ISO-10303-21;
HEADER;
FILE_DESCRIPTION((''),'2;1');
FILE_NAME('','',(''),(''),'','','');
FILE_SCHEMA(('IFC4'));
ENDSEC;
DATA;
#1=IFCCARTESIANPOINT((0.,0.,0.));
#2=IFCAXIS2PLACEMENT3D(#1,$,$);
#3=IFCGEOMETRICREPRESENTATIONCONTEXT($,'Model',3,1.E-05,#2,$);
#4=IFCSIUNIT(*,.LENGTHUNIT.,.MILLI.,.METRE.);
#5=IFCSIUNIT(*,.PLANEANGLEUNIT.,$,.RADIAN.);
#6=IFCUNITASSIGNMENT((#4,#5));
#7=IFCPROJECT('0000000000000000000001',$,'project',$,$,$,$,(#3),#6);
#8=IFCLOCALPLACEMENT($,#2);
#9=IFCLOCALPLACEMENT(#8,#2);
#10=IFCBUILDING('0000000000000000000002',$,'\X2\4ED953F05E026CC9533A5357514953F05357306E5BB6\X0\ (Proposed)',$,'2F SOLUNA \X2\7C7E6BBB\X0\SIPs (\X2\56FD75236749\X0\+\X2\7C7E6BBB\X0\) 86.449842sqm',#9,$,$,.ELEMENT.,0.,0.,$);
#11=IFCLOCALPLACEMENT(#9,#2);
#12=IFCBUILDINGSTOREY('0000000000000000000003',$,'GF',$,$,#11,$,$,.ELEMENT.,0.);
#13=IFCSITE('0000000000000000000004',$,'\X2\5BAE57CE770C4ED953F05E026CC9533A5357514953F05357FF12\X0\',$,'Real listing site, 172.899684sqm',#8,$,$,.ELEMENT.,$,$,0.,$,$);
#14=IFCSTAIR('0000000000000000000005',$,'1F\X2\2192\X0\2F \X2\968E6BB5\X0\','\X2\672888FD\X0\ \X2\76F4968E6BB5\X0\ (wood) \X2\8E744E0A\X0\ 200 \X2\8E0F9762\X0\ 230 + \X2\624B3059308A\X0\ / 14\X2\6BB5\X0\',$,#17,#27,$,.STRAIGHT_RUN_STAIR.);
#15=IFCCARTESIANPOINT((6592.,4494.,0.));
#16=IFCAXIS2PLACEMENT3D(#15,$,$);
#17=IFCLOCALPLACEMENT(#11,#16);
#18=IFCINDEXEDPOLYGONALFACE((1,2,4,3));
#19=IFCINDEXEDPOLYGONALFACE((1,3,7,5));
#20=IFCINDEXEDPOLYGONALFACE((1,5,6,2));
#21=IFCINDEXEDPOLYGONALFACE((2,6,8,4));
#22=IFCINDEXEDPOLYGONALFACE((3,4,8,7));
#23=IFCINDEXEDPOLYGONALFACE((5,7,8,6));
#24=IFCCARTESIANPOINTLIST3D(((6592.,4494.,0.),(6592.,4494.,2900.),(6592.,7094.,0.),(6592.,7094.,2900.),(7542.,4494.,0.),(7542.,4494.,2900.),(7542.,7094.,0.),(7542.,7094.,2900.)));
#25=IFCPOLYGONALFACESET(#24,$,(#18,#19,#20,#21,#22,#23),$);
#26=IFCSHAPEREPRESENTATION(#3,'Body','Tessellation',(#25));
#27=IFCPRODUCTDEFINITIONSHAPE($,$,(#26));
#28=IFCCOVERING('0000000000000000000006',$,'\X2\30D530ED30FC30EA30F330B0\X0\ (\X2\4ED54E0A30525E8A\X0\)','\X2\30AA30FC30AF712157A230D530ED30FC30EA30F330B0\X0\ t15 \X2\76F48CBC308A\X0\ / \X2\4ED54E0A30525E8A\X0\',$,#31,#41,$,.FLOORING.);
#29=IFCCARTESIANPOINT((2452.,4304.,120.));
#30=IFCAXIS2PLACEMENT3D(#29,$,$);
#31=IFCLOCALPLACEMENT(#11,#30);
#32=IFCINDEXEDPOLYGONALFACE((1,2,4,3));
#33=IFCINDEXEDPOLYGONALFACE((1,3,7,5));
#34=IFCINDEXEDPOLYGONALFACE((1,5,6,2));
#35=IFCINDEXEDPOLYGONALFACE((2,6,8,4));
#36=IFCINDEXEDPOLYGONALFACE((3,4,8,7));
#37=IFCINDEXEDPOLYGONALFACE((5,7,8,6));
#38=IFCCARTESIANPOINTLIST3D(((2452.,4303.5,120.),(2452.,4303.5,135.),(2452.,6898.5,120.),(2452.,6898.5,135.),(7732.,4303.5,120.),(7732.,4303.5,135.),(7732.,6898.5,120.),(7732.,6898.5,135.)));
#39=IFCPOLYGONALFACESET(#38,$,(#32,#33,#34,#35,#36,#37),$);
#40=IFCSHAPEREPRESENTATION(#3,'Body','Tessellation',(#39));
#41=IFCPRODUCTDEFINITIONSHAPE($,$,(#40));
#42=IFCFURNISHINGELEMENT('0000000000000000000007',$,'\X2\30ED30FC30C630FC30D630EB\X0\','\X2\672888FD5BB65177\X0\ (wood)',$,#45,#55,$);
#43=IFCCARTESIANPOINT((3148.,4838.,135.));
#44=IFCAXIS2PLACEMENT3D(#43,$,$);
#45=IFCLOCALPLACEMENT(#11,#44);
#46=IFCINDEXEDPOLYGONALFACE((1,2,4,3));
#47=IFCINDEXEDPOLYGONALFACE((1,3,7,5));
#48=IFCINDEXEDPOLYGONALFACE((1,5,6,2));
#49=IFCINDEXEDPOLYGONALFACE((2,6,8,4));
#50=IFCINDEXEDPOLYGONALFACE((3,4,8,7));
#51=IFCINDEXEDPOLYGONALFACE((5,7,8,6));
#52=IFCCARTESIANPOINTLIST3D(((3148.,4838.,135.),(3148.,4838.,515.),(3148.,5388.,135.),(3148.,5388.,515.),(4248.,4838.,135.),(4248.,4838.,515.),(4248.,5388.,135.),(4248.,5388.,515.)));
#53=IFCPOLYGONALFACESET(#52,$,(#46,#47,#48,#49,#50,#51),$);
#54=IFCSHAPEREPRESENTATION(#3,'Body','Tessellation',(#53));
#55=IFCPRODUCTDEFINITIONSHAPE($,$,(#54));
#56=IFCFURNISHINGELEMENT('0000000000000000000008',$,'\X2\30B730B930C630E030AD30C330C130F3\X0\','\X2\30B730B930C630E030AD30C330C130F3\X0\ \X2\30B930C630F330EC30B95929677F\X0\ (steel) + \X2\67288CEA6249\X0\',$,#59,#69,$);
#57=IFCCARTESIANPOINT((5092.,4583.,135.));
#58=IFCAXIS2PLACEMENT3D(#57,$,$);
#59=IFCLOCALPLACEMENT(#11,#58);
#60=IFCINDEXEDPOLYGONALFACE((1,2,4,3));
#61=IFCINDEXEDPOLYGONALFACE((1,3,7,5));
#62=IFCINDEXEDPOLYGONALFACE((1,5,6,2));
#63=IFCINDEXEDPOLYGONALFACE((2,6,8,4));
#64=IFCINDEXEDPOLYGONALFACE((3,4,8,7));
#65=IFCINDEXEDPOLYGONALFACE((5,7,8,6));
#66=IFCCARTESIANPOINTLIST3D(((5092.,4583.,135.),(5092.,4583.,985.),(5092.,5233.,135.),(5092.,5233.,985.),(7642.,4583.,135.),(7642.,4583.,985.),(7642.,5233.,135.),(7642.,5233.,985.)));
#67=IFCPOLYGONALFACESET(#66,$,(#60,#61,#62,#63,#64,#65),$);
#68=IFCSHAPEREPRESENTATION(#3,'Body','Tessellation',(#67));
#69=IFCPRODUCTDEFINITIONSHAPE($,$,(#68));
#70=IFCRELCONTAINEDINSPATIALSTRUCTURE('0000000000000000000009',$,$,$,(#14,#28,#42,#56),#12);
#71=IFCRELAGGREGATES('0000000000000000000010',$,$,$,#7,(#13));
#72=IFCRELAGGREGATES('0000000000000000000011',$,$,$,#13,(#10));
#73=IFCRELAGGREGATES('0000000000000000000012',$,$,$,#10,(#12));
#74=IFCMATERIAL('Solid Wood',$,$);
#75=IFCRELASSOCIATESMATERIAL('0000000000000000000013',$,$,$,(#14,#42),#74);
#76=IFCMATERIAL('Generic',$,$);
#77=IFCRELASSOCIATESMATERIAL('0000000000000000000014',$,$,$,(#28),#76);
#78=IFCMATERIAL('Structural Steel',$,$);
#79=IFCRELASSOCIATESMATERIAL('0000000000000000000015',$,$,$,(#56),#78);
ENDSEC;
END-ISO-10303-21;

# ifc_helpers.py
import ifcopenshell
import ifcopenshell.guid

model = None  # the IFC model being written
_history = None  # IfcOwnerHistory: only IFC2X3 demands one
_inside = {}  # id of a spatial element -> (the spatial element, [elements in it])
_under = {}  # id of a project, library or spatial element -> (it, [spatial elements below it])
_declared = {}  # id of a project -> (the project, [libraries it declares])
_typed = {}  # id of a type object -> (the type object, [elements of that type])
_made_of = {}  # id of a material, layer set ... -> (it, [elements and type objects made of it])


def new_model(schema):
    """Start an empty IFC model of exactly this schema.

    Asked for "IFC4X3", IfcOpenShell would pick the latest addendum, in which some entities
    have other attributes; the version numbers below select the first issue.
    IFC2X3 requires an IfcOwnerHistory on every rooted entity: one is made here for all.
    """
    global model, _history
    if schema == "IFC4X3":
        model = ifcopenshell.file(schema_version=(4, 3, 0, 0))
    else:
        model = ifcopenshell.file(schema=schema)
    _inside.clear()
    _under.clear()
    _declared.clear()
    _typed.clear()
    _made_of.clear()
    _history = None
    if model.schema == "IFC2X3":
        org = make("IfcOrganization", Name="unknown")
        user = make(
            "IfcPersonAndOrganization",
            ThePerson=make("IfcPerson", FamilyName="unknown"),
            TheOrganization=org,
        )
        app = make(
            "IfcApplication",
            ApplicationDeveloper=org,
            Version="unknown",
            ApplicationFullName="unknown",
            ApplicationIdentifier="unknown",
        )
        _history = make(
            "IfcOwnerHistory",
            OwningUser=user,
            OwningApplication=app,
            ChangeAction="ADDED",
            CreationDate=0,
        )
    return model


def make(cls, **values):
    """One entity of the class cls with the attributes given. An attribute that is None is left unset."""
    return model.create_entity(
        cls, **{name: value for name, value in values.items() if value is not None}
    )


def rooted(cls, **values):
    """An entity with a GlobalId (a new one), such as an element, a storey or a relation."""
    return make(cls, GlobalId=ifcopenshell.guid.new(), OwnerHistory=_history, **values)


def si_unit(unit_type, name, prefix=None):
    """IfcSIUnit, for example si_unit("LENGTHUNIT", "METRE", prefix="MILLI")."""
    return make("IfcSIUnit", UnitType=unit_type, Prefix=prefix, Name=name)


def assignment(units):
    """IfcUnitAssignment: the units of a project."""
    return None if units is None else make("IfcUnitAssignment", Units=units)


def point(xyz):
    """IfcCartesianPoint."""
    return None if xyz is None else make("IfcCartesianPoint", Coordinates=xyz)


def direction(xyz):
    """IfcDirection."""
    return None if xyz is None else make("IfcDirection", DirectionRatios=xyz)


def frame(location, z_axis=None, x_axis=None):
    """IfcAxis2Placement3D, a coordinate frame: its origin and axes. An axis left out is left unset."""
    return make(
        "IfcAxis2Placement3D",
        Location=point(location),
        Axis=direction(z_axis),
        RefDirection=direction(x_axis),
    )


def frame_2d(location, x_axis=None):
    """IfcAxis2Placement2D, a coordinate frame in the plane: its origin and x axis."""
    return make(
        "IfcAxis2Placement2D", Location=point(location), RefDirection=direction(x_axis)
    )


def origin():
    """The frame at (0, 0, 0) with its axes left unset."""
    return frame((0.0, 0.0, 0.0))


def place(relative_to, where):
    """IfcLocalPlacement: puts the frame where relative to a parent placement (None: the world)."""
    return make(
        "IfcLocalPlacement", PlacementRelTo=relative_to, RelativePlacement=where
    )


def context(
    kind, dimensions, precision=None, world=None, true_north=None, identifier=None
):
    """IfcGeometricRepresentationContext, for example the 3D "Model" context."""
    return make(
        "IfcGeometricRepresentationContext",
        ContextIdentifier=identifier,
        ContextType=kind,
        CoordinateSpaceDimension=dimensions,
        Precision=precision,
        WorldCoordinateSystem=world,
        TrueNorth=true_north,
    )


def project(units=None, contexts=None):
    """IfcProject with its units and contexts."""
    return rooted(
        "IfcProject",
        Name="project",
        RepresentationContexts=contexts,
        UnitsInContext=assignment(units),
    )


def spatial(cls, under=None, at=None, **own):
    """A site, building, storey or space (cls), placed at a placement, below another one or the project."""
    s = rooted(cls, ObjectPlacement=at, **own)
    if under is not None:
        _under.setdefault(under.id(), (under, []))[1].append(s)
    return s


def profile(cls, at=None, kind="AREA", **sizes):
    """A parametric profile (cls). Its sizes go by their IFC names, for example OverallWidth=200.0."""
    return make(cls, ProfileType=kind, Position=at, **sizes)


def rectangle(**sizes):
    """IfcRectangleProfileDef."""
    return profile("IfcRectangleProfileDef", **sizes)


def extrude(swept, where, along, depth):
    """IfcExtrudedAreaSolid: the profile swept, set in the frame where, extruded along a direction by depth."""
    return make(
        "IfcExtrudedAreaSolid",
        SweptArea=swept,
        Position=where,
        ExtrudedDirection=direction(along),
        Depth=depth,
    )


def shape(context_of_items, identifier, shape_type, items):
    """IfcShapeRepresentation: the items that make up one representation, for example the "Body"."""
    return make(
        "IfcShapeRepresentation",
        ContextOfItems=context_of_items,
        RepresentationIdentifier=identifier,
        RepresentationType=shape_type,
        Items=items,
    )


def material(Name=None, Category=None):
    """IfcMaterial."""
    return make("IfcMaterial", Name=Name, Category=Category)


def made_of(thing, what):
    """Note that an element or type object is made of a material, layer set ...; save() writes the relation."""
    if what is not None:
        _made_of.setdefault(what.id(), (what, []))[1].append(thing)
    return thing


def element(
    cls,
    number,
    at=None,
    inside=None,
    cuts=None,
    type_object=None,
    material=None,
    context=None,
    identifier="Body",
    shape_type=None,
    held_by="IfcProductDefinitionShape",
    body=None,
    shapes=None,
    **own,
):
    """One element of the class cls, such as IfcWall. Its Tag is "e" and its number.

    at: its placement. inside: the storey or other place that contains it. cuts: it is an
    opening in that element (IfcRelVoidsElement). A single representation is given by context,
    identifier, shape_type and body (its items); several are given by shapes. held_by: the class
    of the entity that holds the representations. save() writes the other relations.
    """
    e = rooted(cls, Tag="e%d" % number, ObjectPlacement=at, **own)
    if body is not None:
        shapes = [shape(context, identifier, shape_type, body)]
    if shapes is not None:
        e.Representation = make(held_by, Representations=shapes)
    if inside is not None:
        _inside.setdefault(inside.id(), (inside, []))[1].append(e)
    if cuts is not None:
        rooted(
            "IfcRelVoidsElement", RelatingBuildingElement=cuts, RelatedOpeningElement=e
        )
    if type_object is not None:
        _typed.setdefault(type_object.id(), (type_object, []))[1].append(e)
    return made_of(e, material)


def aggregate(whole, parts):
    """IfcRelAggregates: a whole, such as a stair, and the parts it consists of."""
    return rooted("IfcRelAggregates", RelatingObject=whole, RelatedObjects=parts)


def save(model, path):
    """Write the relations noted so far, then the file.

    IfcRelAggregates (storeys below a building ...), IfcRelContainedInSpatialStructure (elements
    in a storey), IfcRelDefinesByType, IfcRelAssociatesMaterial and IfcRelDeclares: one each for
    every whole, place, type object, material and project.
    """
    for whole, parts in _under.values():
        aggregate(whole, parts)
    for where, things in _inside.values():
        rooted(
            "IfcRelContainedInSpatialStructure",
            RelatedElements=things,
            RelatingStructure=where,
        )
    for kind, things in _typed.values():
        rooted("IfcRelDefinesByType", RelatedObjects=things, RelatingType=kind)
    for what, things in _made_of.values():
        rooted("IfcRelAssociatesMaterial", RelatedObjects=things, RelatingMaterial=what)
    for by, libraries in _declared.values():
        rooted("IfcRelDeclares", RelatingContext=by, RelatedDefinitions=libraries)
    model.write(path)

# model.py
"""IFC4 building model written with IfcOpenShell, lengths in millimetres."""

from ifc_helpers import new_model, si_unit, frame, frame_2d, origin, place, context, project, spatial, rectangle, extrude, material, element, save


model = new_model("IFC4")

# Units and contexts
model_context = context("Model", 3, precision=1e-05, world=origin())
ifc_project = project(units=[si_unit("LENGTHUNIT", "METRE", prefix="MILLI"), si_unit("PLANEANGLEUNIT", "RADIAN")], contexts=[model_context])

# Site, building, storey
site_placement = place(None, origin())
site = spatial("IfcSite", under=ifc_project, at=site_placement, Name="宮城県仙台市泉区南光台南２", ObjectType="Real listing site, 172.899684sqm", CompositionType="ELEMENT", RefElevation=0.0)
building_placement = place(site_placement, origin())
building = spatial("IfcBuilding", under=site, at=building_placement, Name="仙台市泉区南光台南の家 (Proposed)", ObjectType="2F SOLUNA 籾殻SIPs (国産杉+籾殻) 86.449842sqm", CompositionType="ELEMENT", ElevationOfRefHeight=0.0, ElevationOfTerrain=0.0)
storey_placement = place(building_placement, origin())
storey = spatial("IfcBuildingStorey", under=building, at=storey_placement, Name="GF", CompositionType="ELEMENT", Elevation=0.0)

# Shared definitions
ifc_material_1 = material(Name="Solid Wood")

# Stair
stair_placement = place(storey_placement, frame((6592.0, 4494.0, 0.0)))
element("IfcStair", 1, at=stair_placement, inside=storey, material=ifc_material_1, Name="1F→2F 階段", Description="木製 直階段 (wood) 蹴上 200 踏面 230 + 手すり / 14段", PredefinedType="STRAIGHT_RUN_STAIR", context=model_context, shape_type="SweptSolid", body=[
    extrude(rectangle(XDim=950.0, YDim=2600.0, at=frame_2d((475.0, 1300.0))), frame((6592.0, 4494.0, 0.0)), (0.0, 0.0, 1.0), 2900.0),
])

# Covering
ifc_material_2 = material(Name="Generic")
covering_placement = place(storey_placement, frame((2452.0, 4304.0, 120.0)))
element("IfcCovering", 2, at=covering_placement, inside=storey, material=ifc_material_2, Name="フローリング (仕上げ床)", Description="オーク無垢フローリング t15 直貼り / 仕上げ床", PredefinedType="FLOORING", context=model_context, shape_type="SweptSolid", body=[
    extrude(rectangle(XDim=5280.0, YDim=2595.0, at=frame_2d((2640.0, 1297.0))), frame((2452.0, 4304.0, 120.0)), (0.0, 0.0, 1.0), 15.0),
])

# Furnishing elements
furnishing_1_placement = place(storey_placement, frame((3148.0, 4838.0, 135.0)))
element("IfcFurnishingElement", 3, at=furnishing_1_placement, inside=storey, material=ifc_material_1, Name="ローテーブル", Description="木製家具 (wood)", context=model_context, shape_type="SweptSolid", body=[
    extrude(rectangle(XDim=1100.0, YDim=550.0, at=frame_2d((550.0, 275.0))), frame((3148.0, 4838.0, 135.0)), (0.0, 0.0, 1.0), 380.0),
])
ifc_material_3 = material(Name="Structural Steel")
furnishing_2_placement = place(storey_placement, frame((5092.0, 4583.0, 135.0)))
element("IfcFurnishingElement", 4, at=furnishing_2_placement, inside=storey, material=ifc_material_3, Name="システムキッチン", Description="システムキッチン ステンレス天板 (steel) + 木質扉", context=model_context, shape_type="SweptSolid", body=[
    extrude(rectangle(XDim=2550.0, YDim=650.0, at=frame_2d((1275.0, 325.0))), frame((5092.0, 4583.0, 135.0)), (0.0, 0.0, 1.0), 850.0),
])

save(model, "model.ifc")
